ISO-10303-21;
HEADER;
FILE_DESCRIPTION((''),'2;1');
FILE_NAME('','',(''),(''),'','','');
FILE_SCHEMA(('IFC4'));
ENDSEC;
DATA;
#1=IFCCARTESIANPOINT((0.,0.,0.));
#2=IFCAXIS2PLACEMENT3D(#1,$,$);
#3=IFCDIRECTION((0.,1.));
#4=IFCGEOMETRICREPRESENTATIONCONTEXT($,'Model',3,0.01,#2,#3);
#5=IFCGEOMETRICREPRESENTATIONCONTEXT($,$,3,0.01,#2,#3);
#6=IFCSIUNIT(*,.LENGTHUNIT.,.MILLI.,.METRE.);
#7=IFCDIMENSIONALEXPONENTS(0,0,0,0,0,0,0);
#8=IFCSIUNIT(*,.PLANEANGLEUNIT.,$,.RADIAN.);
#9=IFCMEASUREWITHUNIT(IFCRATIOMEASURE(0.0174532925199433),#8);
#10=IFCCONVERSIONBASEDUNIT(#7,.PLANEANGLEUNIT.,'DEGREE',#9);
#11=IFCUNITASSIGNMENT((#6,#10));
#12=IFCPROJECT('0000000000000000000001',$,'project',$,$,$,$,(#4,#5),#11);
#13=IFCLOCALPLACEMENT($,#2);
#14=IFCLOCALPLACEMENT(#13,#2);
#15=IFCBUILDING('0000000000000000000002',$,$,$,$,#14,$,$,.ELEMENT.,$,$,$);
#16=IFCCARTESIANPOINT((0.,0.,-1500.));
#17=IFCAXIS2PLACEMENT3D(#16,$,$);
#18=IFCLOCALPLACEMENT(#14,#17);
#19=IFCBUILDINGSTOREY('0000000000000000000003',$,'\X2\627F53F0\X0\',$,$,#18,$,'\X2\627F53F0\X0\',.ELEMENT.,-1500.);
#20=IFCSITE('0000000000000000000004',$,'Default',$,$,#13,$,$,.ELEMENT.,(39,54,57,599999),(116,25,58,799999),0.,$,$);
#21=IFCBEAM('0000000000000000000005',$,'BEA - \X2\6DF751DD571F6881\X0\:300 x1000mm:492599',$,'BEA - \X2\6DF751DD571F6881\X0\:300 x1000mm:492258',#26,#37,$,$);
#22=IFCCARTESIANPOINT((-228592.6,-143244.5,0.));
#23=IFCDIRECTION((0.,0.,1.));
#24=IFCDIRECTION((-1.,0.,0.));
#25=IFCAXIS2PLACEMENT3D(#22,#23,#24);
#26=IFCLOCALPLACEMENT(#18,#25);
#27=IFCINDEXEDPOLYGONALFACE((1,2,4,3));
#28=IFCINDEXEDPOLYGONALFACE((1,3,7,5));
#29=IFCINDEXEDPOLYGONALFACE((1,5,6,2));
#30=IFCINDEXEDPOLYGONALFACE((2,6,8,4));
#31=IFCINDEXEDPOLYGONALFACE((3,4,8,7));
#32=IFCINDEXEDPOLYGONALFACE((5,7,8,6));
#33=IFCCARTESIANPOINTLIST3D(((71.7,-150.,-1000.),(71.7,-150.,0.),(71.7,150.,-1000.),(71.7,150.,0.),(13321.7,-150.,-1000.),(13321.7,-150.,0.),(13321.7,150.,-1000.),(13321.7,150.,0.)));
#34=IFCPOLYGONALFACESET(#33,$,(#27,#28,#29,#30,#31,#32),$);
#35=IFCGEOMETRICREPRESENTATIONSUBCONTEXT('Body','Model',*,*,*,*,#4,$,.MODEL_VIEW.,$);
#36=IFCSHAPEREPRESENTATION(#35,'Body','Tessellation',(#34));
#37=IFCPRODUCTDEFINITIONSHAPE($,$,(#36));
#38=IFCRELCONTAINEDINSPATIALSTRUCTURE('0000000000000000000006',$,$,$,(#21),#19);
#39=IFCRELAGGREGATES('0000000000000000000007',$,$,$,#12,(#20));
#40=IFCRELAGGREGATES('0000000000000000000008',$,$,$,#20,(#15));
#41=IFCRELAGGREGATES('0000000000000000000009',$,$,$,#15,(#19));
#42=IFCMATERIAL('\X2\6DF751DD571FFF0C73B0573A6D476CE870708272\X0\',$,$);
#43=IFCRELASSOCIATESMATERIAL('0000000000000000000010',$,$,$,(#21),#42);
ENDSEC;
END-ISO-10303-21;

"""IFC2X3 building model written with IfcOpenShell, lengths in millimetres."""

from ifc_helpers import new_model, entity, si_unit, converted_unit, direction, frame, frame_2d, origin, place, context, subcontext, project, spatial, rectangle, extrude, material, element, save


model = new_model("IFC2X3")

# Units and contexts
model_context = context("Model", 3, precision=0.01, world=origin(), true_north=direction((0.0, 1.0)))
context_of_model = context(None, 3, precision=0.01, world=origin(), true_north=direction((0.0, 1.0)))
body_context = subcontext(model_context, "Body", "Model", "MODEL_VIEW")
ifc_project = project(units=[si_unit("LENGTHUNIT", "METRE", prefix="MILLI"), converted_unit("PLANEANGLEUNIT", "DEGREE", entity("IfcRatioMeasure", 0.0174532925199433), si_unit("PLANEANGLEUNIT", "RADIAN"), dimensions=[0, 0, 0, 0, 0, 0, 0])], contexts=[model_context, context_of_model])

# Site, building, storey
site_placement = place(None, origin())
site = spatial("IfcSite", under=ifc_project, at=site_placement, Name="Default", CompositionType="ELEMENT", RefLatitude=(39, 54, 57, 599999), RefLongitude=(116, 25, 58, 799999), RefElevation=0.0)
building_placement = place(site_placement, origin())
building = spatial("IfcBuilding", under=site, at=building_placement, CompositionType="ELEMENT")
storey_placement = place(building_placement, frame((0.0, 0.0, -1500.0)))
storey = spatial("IfcBuildingStorey", under=building, at=storey_placement, Name="承台", LongName="承台", CompositionType="ELEMENT", Elevation=-1500.0)

# Shared definitions
ifc_material_1 = material(Name="混凝土，现场浇注灰色")

# Beam
beam_1_placement = place(storey_placement, frame((-228592.6, -143244.5, 0.0), z_axis=(0.0, 0.0, 1.0), x_axis=(-1.0, 0.0, 0.0)))
element("IfcBeam", 1, at=beam_1_placement, inside=storey, material=ifc_material_1, Name="BEA - 混凝土梁:300 x1000mm:492599", ObjectType="BEA - 混凝土梁:300 x1000mm:492258", context=body_context, shape_type="SweptSolid", body=[
    extrude(rectangle(XDim=1000.0, YDim=300.0, at=frame_2d((0.0, 0.0), x_axis=(1.0, 0.0))), frame((71.7, 0.0, -500.0), z_axis=(1.0, 0.0, 0.0), x_axis=(0.0, 0.0, -1.0)), (0.0, 0.0, 1.0), 13250.0),
])

save(model, "model.ifc")
